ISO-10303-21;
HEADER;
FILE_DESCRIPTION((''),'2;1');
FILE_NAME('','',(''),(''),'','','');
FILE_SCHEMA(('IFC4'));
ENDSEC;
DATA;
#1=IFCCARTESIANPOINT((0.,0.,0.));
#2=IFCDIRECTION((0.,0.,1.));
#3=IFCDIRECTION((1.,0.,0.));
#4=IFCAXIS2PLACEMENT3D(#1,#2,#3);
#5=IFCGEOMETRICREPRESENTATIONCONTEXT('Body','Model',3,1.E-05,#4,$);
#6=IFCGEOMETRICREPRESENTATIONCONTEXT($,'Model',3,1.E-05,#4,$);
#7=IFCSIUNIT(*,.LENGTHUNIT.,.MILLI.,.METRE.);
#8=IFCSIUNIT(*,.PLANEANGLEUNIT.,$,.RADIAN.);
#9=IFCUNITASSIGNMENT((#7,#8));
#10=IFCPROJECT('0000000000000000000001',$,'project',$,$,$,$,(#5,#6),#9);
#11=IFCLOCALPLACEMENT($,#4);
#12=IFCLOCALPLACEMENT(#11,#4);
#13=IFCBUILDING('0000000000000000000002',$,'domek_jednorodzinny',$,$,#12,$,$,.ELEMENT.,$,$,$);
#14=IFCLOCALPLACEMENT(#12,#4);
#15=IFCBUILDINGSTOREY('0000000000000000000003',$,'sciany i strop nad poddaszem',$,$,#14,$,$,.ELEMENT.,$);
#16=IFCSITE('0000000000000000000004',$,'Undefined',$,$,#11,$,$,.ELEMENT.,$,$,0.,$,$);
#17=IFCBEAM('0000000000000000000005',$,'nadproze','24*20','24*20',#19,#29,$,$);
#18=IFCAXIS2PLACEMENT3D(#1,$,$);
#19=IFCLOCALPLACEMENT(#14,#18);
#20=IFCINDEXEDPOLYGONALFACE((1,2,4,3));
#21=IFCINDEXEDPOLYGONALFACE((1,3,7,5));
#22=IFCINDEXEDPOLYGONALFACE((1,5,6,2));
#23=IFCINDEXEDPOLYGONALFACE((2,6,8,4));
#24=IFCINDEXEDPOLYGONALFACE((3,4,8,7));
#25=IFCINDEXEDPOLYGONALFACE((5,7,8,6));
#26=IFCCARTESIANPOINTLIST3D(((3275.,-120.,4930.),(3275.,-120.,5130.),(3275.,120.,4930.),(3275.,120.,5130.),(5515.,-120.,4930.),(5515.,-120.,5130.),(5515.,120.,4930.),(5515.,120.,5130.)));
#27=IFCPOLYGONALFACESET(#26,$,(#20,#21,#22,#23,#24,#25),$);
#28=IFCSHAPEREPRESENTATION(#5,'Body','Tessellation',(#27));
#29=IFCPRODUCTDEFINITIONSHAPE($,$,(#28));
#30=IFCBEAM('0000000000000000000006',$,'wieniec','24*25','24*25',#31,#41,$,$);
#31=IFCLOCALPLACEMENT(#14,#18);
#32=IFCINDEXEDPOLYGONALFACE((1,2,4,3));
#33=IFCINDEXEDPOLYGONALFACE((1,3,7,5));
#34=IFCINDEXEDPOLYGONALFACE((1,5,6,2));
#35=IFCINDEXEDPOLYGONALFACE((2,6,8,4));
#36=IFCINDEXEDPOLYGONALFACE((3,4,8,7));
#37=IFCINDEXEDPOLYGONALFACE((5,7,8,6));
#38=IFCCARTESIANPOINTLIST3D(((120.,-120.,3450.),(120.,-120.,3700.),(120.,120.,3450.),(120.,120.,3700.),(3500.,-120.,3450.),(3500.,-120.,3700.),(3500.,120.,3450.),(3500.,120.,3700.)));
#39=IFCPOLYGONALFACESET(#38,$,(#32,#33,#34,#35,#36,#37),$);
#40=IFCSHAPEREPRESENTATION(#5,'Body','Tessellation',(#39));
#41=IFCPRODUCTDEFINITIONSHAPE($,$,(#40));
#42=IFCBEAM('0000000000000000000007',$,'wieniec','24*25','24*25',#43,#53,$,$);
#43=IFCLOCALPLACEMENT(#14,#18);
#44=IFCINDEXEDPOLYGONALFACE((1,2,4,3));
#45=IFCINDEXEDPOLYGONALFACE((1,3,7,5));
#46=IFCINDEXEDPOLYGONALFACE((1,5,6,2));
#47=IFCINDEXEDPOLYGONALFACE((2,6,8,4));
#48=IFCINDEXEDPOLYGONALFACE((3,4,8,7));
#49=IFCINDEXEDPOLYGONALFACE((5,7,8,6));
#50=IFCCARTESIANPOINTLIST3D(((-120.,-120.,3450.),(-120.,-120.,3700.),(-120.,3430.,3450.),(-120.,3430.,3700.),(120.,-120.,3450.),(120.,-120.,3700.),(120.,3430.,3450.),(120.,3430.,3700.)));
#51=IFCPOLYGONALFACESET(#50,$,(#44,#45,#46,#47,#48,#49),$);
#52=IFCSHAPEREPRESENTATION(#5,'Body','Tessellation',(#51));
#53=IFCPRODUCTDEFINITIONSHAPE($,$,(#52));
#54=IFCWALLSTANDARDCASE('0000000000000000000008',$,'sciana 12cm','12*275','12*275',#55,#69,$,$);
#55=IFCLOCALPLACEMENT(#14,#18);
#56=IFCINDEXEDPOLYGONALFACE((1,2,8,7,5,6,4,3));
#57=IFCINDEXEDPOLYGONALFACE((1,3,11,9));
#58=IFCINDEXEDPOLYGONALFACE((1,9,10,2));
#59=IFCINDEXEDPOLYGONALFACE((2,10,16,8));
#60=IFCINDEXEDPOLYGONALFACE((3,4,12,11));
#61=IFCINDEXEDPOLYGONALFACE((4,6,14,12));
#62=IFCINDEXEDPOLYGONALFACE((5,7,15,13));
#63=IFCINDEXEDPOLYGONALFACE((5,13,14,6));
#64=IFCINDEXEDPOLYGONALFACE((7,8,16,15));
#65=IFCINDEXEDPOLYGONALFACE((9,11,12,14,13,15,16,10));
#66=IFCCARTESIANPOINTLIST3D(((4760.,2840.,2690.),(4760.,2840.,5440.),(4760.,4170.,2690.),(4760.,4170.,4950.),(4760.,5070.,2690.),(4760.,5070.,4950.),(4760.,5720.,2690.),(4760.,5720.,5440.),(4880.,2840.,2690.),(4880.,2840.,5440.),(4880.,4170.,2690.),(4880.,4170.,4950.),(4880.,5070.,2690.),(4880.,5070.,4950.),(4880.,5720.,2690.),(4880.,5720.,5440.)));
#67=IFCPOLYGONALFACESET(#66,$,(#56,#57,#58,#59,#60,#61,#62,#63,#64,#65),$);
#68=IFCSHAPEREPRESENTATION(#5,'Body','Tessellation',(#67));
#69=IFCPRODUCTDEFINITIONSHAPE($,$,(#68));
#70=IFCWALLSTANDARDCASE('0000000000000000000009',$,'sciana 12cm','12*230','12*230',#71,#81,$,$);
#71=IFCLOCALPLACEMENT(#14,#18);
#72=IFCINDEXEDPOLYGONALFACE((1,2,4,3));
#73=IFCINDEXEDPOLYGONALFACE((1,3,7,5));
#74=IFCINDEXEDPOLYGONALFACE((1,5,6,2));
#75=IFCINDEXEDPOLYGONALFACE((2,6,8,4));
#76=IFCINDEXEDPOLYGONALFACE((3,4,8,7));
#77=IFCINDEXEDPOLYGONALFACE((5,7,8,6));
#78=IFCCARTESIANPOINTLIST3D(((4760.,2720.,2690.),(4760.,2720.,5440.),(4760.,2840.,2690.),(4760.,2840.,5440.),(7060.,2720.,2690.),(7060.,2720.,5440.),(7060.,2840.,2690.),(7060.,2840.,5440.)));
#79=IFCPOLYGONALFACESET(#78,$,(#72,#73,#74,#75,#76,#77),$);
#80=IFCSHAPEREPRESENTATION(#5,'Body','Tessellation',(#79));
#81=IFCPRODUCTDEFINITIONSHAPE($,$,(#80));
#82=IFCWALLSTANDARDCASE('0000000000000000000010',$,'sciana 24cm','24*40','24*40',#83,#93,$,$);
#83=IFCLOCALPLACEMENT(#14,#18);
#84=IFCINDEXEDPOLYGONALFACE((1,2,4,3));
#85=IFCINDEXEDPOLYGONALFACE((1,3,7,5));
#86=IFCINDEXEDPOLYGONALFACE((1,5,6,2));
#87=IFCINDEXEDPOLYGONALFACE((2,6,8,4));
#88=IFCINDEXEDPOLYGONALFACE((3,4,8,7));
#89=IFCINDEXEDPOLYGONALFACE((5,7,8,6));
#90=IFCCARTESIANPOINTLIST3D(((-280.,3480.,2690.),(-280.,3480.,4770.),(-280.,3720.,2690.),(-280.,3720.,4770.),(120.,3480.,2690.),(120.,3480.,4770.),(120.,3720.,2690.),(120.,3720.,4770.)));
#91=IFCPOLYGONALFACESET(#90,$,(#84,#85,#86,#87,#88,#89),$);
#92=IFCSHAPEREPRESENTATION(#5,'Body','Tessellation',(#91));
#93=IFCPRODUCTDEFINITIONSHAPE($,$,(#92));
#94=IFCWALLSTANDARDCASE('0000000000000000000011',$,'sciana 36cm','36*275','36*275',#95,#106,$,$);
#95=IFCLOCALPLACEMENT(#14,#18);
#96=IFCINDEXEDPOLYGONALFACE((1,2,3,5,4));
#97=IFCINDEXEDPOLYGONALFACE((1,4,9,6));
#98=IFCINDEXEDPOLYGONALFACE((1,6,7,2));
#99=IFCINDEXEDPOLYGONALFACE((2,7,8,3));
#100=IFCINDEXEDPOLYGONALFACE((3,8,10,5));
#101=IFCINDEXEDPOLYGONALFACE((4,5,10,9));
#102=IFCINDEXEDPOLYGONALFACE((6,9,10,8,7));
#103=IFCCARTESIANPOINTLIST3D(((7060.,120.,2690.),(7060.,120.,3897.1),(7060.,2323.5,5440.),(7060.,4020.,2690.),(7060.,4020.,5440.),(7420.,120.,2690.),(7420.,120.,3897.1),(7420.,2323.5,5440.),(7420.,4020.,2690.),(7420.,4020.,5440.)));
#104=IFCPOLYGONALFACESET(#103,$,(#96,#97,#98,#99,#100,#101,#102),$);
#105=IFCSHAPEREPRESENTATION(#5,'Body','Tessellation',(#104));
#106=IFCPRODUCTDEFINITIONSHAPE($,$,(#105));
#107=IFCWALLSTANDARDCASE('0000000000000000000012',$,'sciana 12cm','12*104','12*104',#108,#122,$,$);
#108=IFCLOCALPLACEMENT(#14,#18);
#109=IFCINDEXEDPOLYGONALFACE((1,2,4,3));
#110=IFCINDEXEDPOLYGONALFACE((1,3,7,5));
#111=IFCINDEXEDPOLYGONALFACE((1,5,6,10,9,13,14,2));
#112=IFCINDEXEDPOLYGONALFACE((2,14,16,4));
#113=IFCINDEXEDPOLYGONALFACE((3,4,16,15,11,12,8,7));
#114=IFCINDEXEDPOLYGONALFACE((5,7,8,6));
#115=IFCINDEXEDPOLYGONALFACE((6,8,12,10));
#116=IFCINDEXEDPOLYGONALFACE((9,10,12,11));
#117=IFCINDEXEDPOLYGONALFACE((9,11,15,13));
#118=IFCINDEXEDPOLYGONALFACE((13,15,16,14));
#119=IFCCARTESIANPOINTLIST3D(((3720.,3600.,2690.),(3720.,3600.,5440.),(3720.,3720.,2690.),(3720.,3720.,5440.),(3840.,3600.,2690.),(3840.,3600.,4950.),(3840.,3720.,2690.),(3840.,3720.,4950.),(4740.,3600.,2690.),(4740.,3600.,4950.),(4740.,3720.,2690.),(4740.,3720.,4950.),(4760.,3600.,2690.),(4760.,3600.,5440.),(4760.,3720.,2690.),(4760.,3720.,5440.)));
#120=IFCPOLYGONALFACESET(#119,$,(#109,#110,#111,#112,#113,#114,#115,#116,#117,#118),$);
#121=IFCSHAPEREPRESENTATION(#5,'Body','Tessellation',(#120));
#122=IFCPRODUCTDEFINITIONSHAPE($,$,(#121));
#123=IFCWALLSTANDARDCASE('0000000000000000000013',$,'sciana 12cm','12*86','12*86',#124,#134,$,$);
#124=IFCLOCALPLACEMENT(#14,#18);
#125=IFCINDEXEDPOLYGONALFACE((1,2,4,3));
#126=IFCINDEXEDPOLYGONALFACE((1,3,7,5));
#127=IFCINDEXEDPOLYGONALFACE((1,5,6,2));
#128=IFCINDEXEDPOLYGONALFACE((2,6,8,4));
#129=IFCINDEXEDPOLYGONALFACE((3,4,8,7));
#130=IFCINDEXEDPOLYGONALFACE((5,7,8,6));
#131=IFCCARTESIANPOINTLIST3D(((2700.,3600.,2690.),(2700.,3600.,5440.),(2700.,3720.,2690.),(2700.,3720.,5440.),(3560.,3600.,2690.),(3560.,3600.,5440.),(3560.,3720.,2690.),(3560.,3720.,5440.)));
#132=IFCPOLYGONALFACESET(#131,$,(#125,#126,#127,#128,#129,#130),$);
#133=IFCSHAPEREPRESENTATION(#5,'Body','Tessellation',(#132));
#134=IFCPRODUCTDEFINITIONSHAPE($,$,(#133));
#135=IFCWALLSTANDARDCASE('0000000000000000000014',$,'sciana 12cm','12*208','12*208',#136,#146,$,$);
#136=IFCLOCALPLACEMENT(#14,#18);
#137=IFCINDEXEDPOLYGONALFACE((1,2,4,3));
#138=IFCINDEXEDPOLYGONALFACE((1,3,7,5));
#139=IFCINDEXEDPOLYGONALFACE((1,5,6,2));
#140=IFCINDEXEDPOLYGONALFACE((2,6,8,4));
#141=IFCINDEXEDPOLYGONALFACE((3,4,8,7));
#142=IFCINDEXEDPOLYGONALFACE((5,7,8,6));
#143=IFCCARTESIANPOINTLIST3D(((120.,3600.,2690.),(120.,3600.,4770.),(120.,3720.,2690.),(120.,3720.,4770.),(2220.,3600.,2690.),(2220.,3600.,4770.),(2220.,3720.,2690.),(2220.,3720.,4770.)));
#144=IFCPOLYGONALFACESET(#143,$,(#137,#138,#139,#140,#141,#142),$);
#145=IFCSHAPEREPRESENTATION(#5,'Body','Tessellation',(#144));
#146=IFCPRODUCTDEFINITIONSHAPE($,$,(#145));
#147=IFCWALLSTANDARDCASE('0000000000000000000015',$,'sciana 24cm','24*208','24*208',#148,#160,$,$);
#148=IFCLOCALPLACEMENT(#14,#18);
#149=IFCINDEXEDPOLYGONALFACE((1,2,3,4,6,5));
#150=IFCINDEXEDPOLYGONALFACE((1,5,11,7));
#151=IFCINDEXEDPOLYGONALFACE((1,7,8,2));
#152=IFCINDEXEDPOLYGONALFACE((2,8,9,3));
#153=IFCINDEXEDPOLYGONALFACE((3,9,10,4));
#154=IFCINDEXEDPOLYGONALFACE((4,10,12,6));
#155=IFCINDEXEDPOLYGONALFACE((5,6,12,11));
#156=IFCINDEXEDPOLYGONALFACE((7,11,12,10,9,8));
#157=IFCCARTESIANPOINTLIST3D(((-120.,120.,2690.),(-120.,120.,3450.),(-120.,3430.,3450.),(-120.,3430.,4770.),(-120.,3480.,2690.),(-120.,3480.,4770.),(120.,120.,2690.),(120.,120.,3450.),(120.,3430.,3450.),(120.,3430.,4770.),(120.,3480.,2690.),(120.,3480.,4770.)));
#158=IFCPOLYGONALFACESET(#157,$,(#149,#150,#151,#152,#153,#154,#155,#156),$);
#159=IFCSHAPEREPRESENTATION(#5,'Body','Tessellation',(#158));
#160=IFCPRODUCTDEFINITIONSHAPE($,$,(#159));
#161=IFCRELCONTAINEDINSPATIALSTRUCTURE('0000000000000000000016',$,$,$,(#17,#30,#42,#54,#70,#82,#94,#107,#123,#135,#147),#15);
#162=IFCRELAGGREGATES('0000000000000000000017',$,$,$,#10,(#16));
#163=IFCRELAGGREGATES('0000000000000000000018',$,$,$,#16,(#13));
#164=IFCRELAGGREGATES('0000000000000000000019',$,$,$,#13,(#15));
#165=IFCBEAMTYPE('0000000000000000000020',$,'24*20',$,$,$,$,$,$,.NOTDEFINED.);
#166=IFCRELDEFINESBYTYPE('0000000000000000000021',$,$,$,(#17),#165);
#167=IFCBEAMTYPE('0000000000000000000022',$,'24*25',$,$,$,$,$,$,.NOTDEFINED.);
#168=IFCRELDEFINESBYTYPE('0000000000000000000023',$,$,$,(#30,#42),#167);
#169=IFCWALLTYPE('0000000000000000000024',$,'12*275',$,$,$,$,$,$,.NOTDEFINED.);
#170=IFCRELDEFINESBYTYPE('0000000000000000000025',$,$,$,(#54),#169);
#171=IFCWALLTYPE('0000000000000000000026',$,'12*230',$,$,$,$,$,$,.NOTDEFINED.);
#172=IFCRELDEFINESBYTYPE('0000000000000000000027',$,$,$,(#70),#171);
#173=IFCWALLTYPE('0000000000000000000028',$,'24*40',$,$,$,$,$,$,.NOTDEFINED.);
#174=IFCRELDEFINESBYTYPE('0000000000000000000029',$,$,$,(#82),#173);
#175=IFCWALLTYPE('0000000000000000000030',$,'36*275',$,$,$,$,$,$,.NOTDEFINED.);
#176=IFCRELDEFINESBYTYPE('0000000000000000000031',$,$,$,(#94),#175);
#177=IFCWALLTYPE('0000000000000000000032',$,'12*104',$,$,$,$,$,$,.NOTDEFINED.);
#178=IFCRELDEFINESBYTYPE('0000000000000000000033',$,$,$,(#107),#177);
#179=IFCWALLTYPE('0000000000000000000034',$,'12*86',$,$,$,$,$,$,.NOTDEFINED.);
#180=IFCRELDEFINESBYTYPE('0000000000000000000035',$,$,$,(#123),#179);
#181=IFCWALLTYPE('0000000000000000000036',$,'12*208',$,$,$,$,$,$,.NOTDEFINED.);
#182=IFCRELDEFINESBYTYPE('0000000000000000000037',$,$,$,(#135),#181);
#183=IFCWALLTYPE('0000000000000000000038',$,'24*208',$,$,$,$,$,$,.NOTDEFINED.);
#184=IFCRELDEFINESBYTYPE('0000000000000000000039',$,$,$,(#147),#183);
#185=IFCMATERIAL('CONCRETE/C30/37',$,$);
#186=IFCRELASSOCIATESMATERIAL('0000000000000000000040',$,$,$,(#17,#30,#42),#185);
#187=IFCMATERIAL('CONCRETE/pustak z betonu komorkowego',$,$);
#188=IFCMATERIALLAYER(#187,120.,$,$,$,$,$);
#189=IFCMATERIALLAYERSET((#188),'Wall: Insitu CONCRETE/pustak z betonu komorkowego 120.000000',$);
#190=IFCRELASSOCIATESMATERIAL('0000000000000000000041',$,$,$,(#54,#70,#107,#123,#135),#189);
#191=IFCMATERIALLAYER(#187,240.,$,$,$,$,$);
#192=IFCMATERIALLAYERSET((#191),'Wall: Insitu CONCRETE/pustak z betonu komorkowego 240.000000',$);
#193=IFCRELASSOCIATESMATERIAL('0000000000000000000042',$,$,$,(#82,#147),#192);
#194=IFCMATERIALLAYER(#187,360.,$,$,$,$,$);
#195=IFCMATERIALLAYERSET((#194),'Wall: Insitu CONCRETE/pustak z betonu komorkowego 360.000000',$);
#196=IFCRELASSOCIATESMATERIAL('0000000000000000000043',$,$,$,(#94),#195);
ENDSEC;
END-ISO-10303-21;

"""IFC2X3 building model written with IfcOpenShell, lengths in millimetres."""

from ifc_helpers import new_model, si_unit, frame, frame_2d, origin_with_axes, origin_2d_with_axis, place, context, project, spatial, polyline, rectangle, outline, extrude, clip, halfspace, material, layer, layer_set, layer_usage, type_object, element, save


model = new_model("IFC2X3")

# Units and contexts
model_context_1 = context("Model", 3, precision=1e-05, world=origin_with_axes(), identifier="Body")
model_context_2 = context("Model", 3, precision=1e-05, world=origin_with_axes())
ifc_project = project(units=[si_unit("LENGTHUNIT", "METRE", prefix="MILLI"), si_unit("PLANEANGLEUNIT", "RADIAN")], contexts=[model_context_1, model_context_2])

# Site, building, storey
site_placement = place(None, origin_with_axes())
site = spatial("IfcSite", under=ifc_project, at=site_placement, Name="Undefined", CompositionType="ELEMENT", RefElevation=0.0)
building_placement = place(site_placement, origin_with_axes())
building = spatial("IfcBuilding", under=site, at=building_placement, Name="domek_jednorodzinny", CompositionType="ELEMENT")
storey_placement = place(building_placement, origin_with_axes())
storey = spatial("IfcBuildingStorey", under=building, at=storey_placement, Name="sciany i strop nad poddaszem", CompositionType="ELEMENT")

# Beams
ifc_material_1 = material(Name="CONCRETE/C30/37")
beam_type_1 = type_object("IfcBeamType", Name="24*20", PredefinedType="NOTDEFINED")
beam_1_placement = place(storey_placement, frame((3275.0, 0.0, 5030.0), z_axis=(0.0, 0.0, 1.0), x_axis=(1.0, 0.0, 0.0)))
element("IfcBeam", 1, at=beam_1_placement, inside=storey, type_object=beam_type_1, material=ifc_material_1, Name="nadproze", Description="24*20", ObjectType="24*20", context=model_context_1, shape_type="SweptSolid", body=[
    extrude(rectangle(XDim=240.0, YDim=200.0, at=origin_2d_with_axis()), frame((2240.0, 0.0, 0.0), z_axis=(-1.0, 0.0, 0.0), x_axis=(0.0, -1.0, 0.0)), (0.0, 0.0, 1.0), 2240.0),
])
beam_type_2 = type_object("IfcBeamType", Name="24*25", PredefinedType="NOTDEFINED")
beam_2_placement = place(storey_placement, frame((3500.0, 0.0, 3575.0), z_axis=(0.0, 0.0, 1.0), x_axis=(-1.0, 0.0, 0.0)))
element("IfcBeam", 2, at=beam_2_placement, inside=storey, type_object=beam_type_2, material=ifc_material_1, Name="wieniec", Description="24*25", ObjectType="24*25", context=model_context_1, shape_type="SweptSolid", body=[
    extrude(rectangle(XDim=240.0, YDim=250.0, at=origin_2d_with_axis()), frame((3380.0, 0.0, 0.0), z_axis=(-1.0, 0.0, 0.0), x_axis=(0.0, -1.0, 0.0)), (0.0, 0.0, 1.0), 3380.0),
])
beam_3_placement = place(storey_placement, frame((0.0, 3430.0, 3575.0), z_axis=(0.0, 0.0, 1.0), x_axis=(0.0, -1.0, 0.0)))
element("IfcBeam", 3, at=beam_3_placement, inside=storey, type_object=beam_type_2, material=ifc_material_1, Name="wieniec", Description="24*25", ObjectType="24*25", context=model_context_1, shape_type="SweptSolid", body=[
    extrude(rectangle(XDim=240.0, YDim=250.0, at=origin_2d_with_axis()), frame((3550.0, 0.0, 0.0), z_axis=(-1.0, 0.0, 0.0), x_axis=(0.0, -1.0, 0.0)), (0.0, 0.0, 1.0), 3550.0),
])

# Wall, opening
ifc_material_2 = material(Name="CONCRETE/pustak z betonu komorkowego")
ifc_layer_1 = layer(ifc_material_2, 120.0)
ifc_layer_set_1 = layer_set([ifc_layer_1], Name="Wall: Insitu CONCRETE/pustak z betonu komorkowego 120.000000")
ifc_layer_usage_1 = layer_usage(ifc_layer_set_1, "AXIS2", "POSITIVE", -60.0)
wall_type_1 = type_object("IfcWallType", Name="12*275", PredefinedType="NOTDEFINED")
wall_1_placement = place(storey_placement, frame((4820.0, 2840.0, 2690.0), z_axis=(0.0, 0.0, 1.0), x_axis=(0.0, 1.0, 0.0)))
wall_1 = element("IfcWallStandardCase", 4, at=wall_1_placement, inside=storey, type_object=wall_type_1, material=ifc_layer_usage_1, Name="sciana 12cm", Description="12*275", ObjectType="12*275", context=model_context_1, shape_type="SweptSolid", body=[
    extrude(rectangle(XDim=2880.0, YDim=120.0, at=frame_2d((0.0, 1440.0), x_axis=(0.0, -1.0))), frame((0.0, 0.0, 0.0), z_axis=(0.0, 0.0, 1.0), x_axis=(0.0, -1.0, 0.0)), (0.0, 0.0, 1.0), 2750.0),
])
opening_1_placement = place(storey_placement, frame((4820.0, 2840.0, 2690.0), z_axis=(0.0, 0.0, 1.0), x_axis=(0.0, 1.0, 0.0)))
element("IfcOpeningElement", 5, at=opening_1_placement, cuts=wall_1, ObjectType="Recess", context=model_context_1, shape_type="SweptSolid", body=[
    extrude(outline(polyline([(0.0, 0.0), (520.0, 0.0), (520.0, 900.0), (0.0, 900.0), (0.0, 0.0)])), frame((1330.0, -260.0, 2260.0), z_axis=(0.000001, 0.000001, -1.0), x_axis=(0.0, 1.0, 0.0)), (0.0, 0.0, 1.0), 2260.0),
])

# Walls
ifc_layer_usage_2 = layer_usage(ifc_layer_set_1, "AXIS2", "POSITIVE", -60.0)
wall_type_2 = type_object("IfcWallType", Name="12*230", PredefinedType="NOTDEFINED")
wall_2_placement = place(storey_placement, frame((4760.0, 2780.0, 2690.0), z_axis=(0.0, 0.0, 1.0), x_axis=(1.0, 0.0, 0.0)))
element("IfcWallStandardCase", 6, at=wall_2_placement, inside=storey, type_object=wall_type_2, material=ifc_layer_usage_2, Name="sciana 12cm", Description="12*230", ObjectType="12*230", context=model_context_1, shape_type="SweptSolid", body=[
    extrude(rectangle(XDim=2300.0, YDim=120.0, at=frame_2d((0.0, 1150.0), x_axis=(0.0, -1.0))), frame((0.0, 0.0, 0.0), z_axis=(0.0, 0.0, 1.0), x_axis=(0.0, -1.0, 0.0)), (0.0, 0.0, 1.0), 2750.0),
])
ifc_layer_2 = layer(ifc_material_2, 240.0)
ifc_layer_set_2 = layer_set([ifc_layer_2], Name="Wall: Insitu CONCRETE/pustak z betonu komorkowego 240.000000")
ifc_layer_usage_3 = layer_usage(ifc_layer_set_2, "AXIS2", "POSITIVE", -120.0)
wall_type_3 = type_object("IfcWallType", Name="24*40", PredefinedType="NOTDEFINED")
wall_3_placement = place(storey_placement, frame((-280.0, 3600.0, 2690.0), z_axis=(0.0, 0.0, 1.0), x_axis=(1.0, 0.0, 0.0)))
element("IfcWallStandardCase", 7, at=wall_3_placement, inside=storey, type_object=wall_type_3, material=ifc_layer_usage_3, Name="sciana 24cm", Description="24*40", ObjectType="24*40", context=model_context_1, shape_type="SweptSolid", body=[
    extrude(rectangle(XDim=400.0, YDim=240.0, at=frame_2d((0.0, 200.0), x_axis=(0.0, -1.0))), frame((0.0, 0.0, 0.0), z_axis=(0.0, 0.0, 1.0), x_axis=(0.0, -1.0, 0.0)), (0.0, 0.0, 1.0), 2080.0),
])
ifc_layer_3 = layer(ifc_material_2, 360.0)
ifc_layer_set_3 = layer_set([ifc_layer_3], Name="Wall: Insitu CONCRETE/pustak z betonu komorkowego 360.000000")
ifc_layer_usage_4 = layer_usage(ifc_layer_set_3, "AXIS2", "POSITIVE", -180.0)
wall_type_4 = type_object("IfcWallType", Name="36*275", PredefinedType="NOTDEFINED")
wall_4_placement = place(storey_placement, frame((7240.0, 120.0, 2690.0), z_axis=(0.0, 0.0, 1.0), x_axis=(0.0, 1.0, 0.0)))
element("IfcWallStandardCase", 8, at=wall_4_placement, inside=storey, type_object=wall_type_4, material=ifc_layer_usage_4, Name="sciana 36cm", Description="36*275", ObjectType="36*275", context=model_context_1, shape_type="Clipping", body=[
    clip(extrude(rectangle(XDim=3900.0, YDim=360.0, at=frame_2d((0.0, 1950.0), x_axis=(0.0, -1.0))), frame((0.0, 0.0, 0.0), z_axis=(0.0, 0.0, 1.0), x_axis=(0.0, -1.0, 0.0)), (0.0, 0.0, 1.0), 2750.0), halfspace(frame((-1759.6, 180.0, -25.0), z_axis=(-0.573576, 0.0, 0.819152), x_axis=(0.819152, 0.0, 0.573576)), False)),
])

# Wall, opening
ifc_layer_usage_5 = layer_usage(ifc_layer_set_1, "AXIS2", "POSITIVE", -60.0)
wall_type_5 = type_object("IfcWallType", Name="12*104", PredefinedType="NOTDEFINED")
wall_5_placement = place(storey_placement, frame((3720.0, 3660.0, 2690.0), z_axis=(0.0, 0.0, 1.0), x_axis=(1.0, 0.0, 0.0)))
wall_5 = element("IfcWallStandardCase", 9, at=wall_5_placement, inside=storey, type_object=wall_type_5, material=ifc_layer_usage_5, Name="sciana 12cm", Description="12*104", ObjectType="12*104", context=model_context_1, shape_type="SweptSolid", body=[
    extrude(rectangle(XDim=1040.0, YDim=120.0, at=frame_2d((0.0, 520.0), x_axis=(0.0, -1.0))), frame((0.0, 0.0, 0.0), z_axis=(0.0, 0.0, 1.0), x_axis=(0.0, -1.0, 0.0)), (0.0, 0.0, 1.0), 2750.0),
])
opening_2_placement = place(storey_placement, frame((3720.0, 3660.0, 2690.0), z_axis=(0.0, 0.0, 1.0), x_axis=(1.0, 0.0, 0.0)))
element("IfcOpeningElement", 10, at=opening_2_placement, cuts=wall_5, ObjectType="Recess", context=model_context_1, shape_type="SweptSolid", body=[
    extrude(outline(polyline([(0.0, 0.0), (120.0, 0.0), (120.0, 900.0), (0.0, 900.0), (0.0, 0.0)])), frame((1020.0, -60.0, 0.0), z_axis=(0.0, 0.0, 1.0), x_axis=(0.0, 1.0, 0.0)), (0.0, 0.0, 1.0), 2260.0),
])

# Walls
ifc_layer_usage_6 = layer_usage(ifc_layer_set_1, "AXIS2", "POSITIVE", -60.0)
wall_type_6 = type_object("IfcWallType", Name="12*86", PredefinedType="NOTDEFINED")
wall_6_placement = place(storey_placement, frame((2700.0, 3660.0, 2690.0), z_axis=(0.0, 0.0, 1.0), x_axis=(1.0, 0.0, 0.0)))
element("IfcWallStandardCase", 11, at=wall_6_placement, inside=storey, type_object=wall_type_6, material=ifc_layer_usage_6, Name="sciana 12cm", Description="12*86", ObjectType="12*86", context=model_context_1, shape_type="SweptSolid", body=[
    extrude(rectangle(XDim=860.0, YDim=120.0, at=frame_2d((0.0, 430.0), x_axis=(0.0, -1.0))), frame((0.0, 0.0, 0.0), z_axis=(0.0, 0.0, 1.0), x_axis=(0.0, -1.0, 0.0)), (0.0, 0.0, 1.0), 2750.0),
])
ifc_layer_usage_7 = layer_usage(ifc_layer_set_1, "AXIS2", "POSITIVE", -60.0)
wall_type_7 = type_object("IfcWallType", Name="12*208", PredefinedType="NOTDEFINED")
wall_7_placement = place(storey_placement, frame((120.0, 3660.0, 2690.0), z_axis=(0.0, 0.0, 1.0), x_axis=(1.0, 0.0, 0.0)))
element("IfcWallStandardCase", 12, at=wall_7_placement, inside=storey, type_object=wall_type_7, material=ifc_layer_usage_7, Name="sciana 12cm", Description="12*208", ObjectType="12*208", context=model_context_1, shape_type="SweptSolid", body=[
    extrude(rectangle(XDim=2100.0, YDim=120.0, at=frame_2d((0.0, 1050.0), x_axis=(0.0, -1.0))), frame((0.0, 0.0, 0.0), z_axis=(0.0, 0.0, 1.0), x_axis=(0.0, -1.0, 0.0)), (0.0, 0.0, 1.0), 2080.0),
])

# Wall, opening
ifc_layer_usage_8 = layer_usage(ifc_layer_set_2, "AXIS2", "POSITIVE", -120.0)
wall_type_8 = type_object("IfcWallType", Name="24*208", PredefinedType="NOTDEFINED")
wall_8_placement = place(storey_placement, frame((0.0, 120.0, 2690.0), z_axis=(0.0, 0.0, 1.0), x_axis=(0.0, 1.0, 0.0)))
wall_8 = element("IfcWallStandardCase", 13, at=wall_8_placement, inside=storey, type_object=wall_type_8, material=ifc_layer_usage_8, Name="sciana 24cm", Description="24*208", ObjectType="24*208", context=model_context_1, shape_type="SweptSolid", body=[
    extrude(rectangle(XDim=3360.0, YDim=240.0, at=frame_2d((0.0, 1680.0), x_axis=(0.0, -1.0))), frame((0.0, 0.0, 0.0), z_axis=(0.0, 0.0, 1.0), x_axis=(0.0, -1.0, 0.0)), (0.0, 0.0, 1.0), 2080.0),
])
opening_3_placement = place(storey_placement, frame((0.0, 120.0, 2690.0), z_axis=(0.0, 0.0, 1.0), x_axis=(0.0, 1.0, 0.0)))
element("IfcOpeningElement", 14, at=opening_3_placement, cuts=wall_8, ObjectType="Recess", context=model_context_1, shape_type="SweptSolid", body=[
    extrude(outline(polyline([(0.0, 0.0), (1700.0, 0.0), (1700.0, 3310.0), (0.0, 3310.0), (0.0, 0.0)])), frame((3310.0, 153.0, 760.0), z_axis=(0.0, -1.0, 0.0), x_axis=(0.0, 0.0, 1.0)), (0.0, 0.0, 1.0), 306.0),
])

save(model, "model.ifc")
